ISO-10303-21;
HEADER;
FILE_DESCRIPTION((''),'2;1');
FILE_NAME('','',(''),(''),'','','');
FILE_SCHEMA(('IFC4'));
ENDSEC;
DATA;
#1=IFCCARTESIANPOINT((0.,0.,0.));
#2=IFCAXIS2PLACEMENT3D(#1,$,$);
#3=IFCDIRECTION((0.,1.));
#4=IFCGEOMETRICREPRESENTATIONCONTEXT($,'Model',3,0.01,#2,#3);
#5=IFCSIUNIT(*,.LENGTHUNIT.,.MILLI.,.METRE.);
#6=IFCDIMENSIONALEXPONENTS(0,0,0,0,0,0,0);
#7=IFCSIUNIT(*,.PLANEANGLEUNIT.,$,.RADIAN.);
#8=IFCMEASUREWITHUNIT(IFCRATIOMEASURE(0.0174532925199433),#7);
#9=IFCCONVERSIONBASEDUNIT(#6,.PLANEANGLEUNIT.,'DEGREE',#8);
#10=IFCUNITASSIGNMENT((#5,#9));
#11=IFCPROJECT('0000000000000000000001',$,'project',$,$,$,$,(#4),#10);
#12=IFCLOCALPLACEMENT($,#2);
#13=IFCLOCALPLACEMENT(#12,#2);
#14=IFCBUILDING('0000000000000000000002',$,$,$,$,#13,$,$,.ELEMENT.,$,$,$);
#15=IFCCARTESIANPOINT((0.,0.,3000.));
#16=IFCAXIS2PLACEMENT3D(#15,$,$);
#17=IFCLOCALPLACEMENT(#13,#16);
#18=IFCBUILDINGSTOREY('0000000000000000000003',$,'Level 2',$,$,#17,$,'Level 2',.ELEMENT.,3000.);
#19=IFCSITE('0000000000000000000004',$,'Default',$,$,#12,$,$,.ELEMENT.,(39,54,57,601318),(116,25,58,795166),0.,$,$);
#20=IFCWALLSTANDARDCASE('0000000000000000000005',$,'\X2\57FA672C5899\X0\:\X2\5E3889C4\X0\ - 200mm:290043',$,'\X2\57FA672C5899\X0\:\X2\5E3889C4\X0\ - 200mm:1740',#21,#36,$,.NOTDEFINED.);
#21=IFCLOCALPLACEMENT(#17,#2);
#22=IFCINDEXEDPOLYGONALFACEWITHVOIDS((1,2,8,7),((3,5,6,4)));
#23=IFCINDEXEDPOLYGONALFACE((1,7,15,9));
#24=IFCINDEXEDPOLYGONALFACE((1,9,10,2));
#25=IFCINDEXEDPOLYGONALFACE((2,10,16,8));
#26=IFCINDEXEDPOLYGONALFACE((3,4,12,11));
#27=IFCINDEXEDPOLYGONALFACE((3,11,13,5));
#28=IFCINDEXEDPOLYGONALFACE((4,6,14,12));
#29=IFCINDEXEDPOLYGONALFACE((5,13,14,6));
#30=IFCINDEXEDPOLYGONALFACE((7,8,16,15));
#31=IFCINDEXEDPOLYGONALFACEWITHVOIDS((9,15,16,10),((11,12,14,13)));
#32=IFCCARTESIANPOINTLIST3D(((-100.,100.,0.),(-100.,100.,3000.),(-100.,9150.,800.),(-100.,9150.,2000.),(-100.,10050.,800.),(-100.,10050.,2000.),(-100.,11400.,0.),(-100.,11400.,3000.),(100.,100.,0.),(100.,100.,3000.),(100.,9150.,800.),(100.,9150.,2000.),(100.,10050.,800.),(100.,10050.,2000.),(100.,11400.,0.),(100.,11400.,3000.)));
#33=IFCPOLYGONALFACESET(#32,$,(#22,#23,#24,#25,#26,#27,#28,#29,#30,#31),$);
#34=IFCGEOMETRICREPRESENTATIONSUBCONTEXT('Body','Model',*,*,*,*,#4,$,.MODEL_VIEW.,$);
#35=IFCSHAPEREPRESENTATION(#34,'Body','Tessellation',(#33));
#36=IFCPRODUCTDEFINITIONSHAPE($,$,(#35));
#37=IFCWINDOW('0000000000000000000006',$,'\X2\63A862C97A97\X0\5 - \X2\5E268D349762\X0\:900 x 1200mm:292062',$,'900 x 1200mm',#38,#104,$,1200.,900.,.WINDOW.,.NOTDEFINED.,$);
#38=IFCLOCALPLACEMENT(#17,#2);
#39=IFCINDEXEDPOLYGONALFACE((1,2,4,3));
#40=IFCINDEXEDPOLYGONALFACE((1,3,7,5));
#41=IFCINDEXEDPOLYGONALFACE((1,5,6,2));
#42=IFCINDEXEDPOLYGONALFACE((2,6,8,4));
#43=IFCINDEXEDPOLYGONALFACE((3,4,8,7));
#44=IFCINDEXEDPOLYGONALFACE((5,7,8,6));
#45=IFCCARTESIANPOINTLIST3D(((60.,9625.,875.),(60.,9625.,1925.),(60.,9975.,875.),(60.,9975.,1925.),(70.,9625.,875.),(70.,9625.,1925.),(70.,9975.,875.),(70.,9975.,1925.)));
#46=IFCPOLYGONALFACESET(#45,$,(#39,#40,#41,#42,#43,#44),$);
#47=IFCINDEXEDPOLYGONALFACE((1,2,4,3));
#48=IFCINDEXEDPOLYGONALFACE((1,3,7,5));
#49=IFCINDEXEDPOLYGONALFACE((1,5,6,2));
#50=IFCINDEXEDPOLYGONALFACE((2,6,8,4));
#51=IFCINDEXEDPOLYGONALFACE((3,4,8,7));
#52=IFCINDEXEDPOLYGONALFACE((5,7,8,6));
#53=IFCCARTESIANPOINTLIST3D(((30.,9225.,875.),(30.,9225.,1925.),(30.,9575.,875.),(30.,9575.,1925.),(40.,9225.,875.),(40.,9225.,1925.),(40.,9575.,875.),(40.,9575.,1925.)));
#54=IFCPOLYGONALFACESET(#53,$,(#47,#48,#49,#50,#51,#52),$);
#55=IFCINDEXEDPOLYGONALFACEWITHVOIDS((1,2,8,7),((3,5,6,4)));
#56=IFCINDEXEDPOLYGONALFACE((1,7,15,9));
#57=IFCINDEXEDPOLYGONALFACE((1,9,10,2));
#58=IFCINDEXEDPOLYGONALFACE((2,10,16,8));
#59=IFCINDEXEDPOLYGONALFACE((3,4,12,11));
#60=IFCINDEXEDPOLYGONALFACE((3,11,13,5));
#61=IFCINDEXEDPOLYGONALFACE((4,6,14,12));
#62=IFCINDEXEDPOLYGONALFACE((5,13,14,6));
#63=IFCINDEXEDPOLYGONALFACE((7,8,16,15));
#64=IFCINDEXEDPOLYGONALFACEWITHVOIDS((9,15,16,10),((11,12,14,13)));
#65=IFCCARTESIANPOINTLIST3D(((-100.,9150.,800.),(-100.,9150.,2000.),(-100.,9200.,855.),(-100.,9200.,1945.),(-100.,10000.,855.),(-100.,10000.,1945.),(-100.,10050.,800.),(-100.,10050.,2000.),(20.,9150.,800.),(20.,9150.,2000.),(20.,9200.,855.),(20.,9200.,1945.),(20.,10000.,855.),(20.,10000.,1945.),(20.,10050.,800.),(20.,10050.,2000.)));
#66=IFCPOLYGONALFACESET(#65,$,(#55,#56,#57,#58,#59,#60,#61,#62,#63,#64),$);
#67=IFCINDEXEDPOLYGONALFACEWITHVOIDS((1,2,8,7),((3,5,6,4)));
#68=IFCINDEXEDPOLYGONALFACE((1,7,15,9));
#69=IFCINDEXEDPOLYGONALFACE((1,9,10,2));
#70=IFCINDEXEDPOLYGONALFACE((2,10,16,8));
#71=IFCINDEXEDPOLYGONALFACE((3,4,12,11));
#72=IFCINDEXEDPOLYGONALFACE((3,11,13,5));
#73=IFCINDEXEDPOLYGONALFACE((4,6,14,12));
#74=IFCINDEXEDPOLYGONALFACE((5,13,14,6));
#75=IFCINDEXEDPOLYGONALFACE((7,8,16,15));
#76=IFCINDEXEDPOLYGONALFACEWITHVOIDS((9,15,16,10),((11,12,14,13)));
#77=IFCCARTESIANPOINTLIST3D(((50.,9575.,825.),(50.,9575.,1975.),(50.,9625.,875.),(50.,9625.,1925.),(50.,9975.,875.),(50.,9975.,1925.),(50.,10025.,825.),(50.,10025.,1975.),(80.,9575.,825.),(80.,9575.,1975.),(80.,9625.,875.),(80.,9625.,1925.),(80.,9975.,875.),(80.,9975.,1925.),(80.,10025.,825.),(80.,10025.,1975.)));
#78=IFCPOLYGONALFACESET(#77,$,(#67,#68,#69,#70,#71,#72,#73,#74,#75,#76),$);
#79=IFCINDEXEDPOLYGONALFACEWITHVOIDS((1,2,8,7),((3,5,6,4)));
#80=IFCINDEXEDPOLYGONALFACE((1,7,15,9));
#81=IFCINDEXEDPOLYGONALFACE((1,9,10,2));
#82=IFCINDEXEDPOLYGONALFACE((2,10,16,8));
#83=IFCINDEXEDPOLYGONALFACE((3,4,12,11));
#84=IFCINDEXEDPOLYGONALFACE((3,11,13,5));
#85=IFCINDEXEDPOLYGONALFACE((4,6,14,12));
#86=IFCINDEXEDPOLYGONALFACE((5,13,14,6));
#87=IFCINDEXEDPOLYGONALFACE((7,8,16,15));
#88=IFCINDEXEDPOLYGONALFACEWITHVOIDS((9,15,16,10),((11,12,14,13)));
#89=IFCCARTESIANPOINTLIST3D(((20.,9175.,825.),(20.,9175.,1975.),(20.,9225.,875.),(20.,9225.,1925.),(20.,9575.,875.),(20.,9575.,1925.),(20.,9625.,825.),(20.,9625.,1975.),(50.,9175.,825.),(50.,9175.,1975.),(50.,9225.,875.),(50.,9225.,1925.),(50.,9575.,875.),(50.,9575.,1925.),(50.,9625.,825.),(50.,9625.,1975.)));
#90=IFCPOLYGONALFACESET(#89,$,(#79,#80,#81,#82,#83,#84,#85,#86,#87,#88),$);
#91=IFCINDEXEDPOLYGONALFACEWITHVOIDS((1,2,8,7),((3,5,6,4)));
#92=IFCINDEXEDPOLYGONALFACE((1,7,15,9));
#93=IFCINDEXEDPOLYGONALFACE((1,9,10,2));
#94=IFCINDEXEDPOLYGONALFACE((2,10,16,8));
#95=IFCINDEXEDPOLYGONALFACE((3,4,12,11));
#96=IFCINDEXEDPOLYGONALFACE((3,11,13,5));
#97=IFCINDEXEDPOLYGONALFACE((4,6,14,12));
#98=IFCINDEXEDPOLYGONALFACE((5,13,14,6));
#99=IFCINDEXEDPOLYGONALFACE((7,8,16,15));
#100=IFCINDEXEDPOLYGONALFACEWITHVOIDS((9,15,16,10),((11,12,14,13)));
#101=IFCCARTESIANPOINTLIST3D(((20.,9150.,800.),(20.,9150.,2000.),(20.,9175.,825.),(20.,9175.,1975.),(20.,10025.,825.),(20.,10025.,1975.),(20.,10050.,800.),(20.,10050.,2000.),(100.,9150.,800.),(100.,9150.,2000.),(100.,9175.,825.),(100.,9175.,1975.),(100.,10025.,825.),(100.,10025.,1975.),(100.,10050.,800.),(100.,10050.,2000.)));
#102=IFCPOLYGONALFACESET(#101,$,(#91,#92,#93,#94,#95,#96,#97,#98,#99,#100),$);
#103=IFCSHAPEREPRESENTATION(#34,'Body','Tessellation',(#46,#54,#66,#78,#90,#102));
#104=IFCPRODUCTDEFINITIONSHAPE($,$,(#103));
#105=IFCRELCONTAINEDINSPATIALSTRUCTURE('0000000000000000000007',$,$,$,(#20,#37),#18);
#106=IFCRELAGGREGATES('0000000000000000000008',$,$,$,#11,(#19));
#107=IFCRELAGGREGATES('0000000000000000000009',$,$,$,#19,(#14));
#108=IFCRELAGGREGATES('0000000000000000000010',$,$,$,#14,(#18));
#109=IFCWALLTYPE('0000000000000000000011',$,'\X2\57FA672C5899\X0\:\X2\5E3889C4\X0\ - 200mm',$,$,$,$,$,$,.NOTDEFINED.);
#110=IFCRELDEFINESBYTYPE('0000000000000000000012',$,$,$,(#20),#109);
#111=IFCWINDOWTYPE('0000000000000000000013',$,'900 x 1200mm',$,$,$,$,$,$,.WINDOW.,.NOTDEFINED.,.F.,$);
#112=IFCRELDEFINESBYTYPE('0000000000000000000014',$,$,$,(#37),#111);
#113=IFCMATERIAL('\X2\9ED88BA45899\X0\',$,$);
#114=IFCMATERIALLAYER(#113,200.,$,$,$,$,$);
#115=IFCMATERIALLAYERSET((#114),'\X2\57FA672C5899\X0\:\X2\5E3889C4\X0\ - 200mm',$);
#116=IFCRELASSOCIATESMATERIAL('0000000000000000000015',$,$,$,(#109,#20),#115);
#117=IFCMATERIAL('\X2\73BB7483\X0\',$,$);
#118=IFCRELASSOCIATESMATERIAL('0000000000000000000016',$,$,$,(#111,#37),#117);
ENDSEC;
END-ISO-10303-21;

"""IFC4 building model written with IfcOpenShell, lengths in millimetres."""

from ifc_helpers import new_model, entity, si_unit, converted_unit, direction, frame, frame_2d, origin, origin_2d_with_axis, place, context, subcontext, project, spatial, polyline, rectangle, outline, extrude, source, transform, mapped, material, layer, layer_set, layer_usage, type_object, type_shapes, element, fill, save


model = new_model("IFC4")

# Units and contexts
model_context = context("Model", 3, precision=0.01, world=origin(), true_north=direction((0.0, 1.0)))
body_context = subcontext(model_context, "Body", "Model", "MODEL_VIEW")
ifc_project = project(units=[si_unit("LENGTHUNIT", "METRE", prefix="MILLI"), converted_unit("PLANEANGLEUNIT", "DEGREE", entity("IfcRatioMeasure", 0.0174532925199433), si_unit("PLANEANGLEUNIT", "RADIAN"), dimensions=[0, 0, 0, 0, 0, 0, 0])], contexts=[model_context])

# Site, building, storey
site_placement = place(None, origin())
site = spatial("IfcSite", under=ifc_project, at=site_placement, Name="Default", CompositionType="ELEMENT", RefLatitude=(39, 54, 57, 601318), RefLongitude=(116, 25, 58, 795166), RefElevation=0.0)
building_placement = place(site_placement, origin())
building = spatial("IfcBuilding", under=site, at=building_placement, CompositionType="ELEMENT")
storey_placement = place(building_placement, frame((0.0, 0.0, 3000.0)))
storey = spatial("IfcBuildingStorey", under=building, at=storey_placement, Name="Level 2", LongName="Level 2", CompositionType="ELEMENT", Elevation=3000.0)

# Shared definitions
ifc_material_1 = material(Name="默认墙")
ifc_layer_1 = layer(ifc_material_1, 200.0)
ifc_layer_set_1 = layer_set([ifc_layer_1], Name="基本墙:常规 - 200mm")
wall_type = type_object("IfcWallType", Name="基本墙:常规 - 200mm", PredefinedType="NOTDEFINED", material=ifc_layer_set_1)

# Wall, opening, window
ifc_material_2 = material(Name="玻璃")
window_type = type_object("IfcWindowType", Name="900 x 1200mm", ParameterTakesPrecedence=False, PartitioningType="NOTDEFINED", PredefinedType="WINDOW", material=ifc_material_2)
shared_shape_1 = source(origin(), body_context, "Body", "SweptSolid", [
    extrude(rectangle(XDim=10.0, YDim=350.0, at=origin_2d_with_axis()), frame((250.0, 165.0, 75.0), z_axis=(0.0, 0.0, 1.0), x_axis=(0.0, -1.0, 0.0)), (0.0, 0.0, 1.0), 1050.0),
    extrude(rectangle(XDim=10.0, YDim=350.0, at=origin_2d_with_axis()), frame((650.0, 135.0, 75.0), z_axis=(0.0, 0.0, 1.0), x_axis=(0.0, -1.0, 0.0)), (0.0, 0.0, 1.0), 1050.0),
    extrude(outline(polyline([(-450.0, -600.0), (450.0, -600.0), (450.0, 600.0), (-450.0, 600.0), (-450.0, -600.0)]), holes=[polyline([(400.0, -545.0), (-400.0, -545.0), (-400.0, 545.0), (400.0, 545.0), (400.0, -545.0)])]), frame((450.0, 0.0, 600.0), z_axis=(0.0, 1.0, 0.0), x_axis=(1.0, 0.0, 0.0)), (0.0, 0.0, 1.0), 120.0),
    extrude(outline(polyline([(-225.0, -575.0), (225.0, -575.0), (225.0, 575.0), (-225.0, 575.0), (-225.0, -575.0)]), holes=[polyline([(-175.0, -525.0), (-175.0, 525.0), (175.0, 525.0), (175.0, -525.0), (-175.0, -525.0)])]), frame((250.0, 150.0, 600.0), z_axis=(0.0, 1.0, 0.0), x_axis=(-1.0, 0.0, 0.0)), (0.0, 0.0, 1.0), 30.0),
    extrude(outline(polyline([(-225.0, -575.0), (225.0, -575.0), (225.0, 575.0), (-225.0, 575.0), (-225.0, -575.0)]), holes=[polyline([(-175.0, -525.0), (-175.0, 525.0), (175.0, 525.0), (175.0, -525.0), (-175.0, -525.0)])]), frame((650.0, 120.0, 600.0), z_axis=(0.0, 1.0, 0.0), x_axis=(1.0, 0.0, 0.0)), (0.0, 0.0, 1.0), 30.0),
    extrude(outline(polyline([(-450.0, -600.0), (450.0, -600.0), (450.0, 600.0), (-450.0, 600.0), (-450.0, -600.0)]), holes=[polyline([(-425.0, 575.0), (425.0, 575.0), (425.0, -575.0), (-425.0, -575.0), (-425.0, 575.0)])]), frame((450.0, 120.0, 600.0), z_axis=(0.0, 1.0, 0.0), x_axis=(1.0, 0.0, 0.0)), (0.0, 0.0, 1.0), 80.0),
])
type_shapes(window_type, [shared_shape_1])
ifc_layer_usage_1 = layer_usage(ifc_layer_set_1, "AXIS2", "NEGATIVE", 100.0)
wall_1_placement = place(storey_placement, frame((0.0, 100.0, 0.0), z_axis=(0.0, 0.0, 1.0), x_axis=(0.0, 1.0, 0.0)))
wall_1 = element("IfcWallStandardCase", 1, at=wall_1_placement, inside=storey, type_object=wall_type, material=ifc_layer_usage_1, Name="基本墙:常规 - 200mm:290043", ObjectType="基本墙:常规 - 200mm:1740", PredefinedType="NOTDEFINED", context=body_context, shape_type="SweptSolid", body=[
    extrude(rectangle(XDim=11300.0, YDim=200.0, at=frame_2d((5650.0, 0.0), x_axis=(-1.0, 0.0))), origin(), (0.0, 0.0, 1.0), 3000.0),
])
opening_1_placement = place(wall_1_placement, frame((9950.0, 100.0, 800.0)))
opening_1 = element("IfcOpeningElement", 2, at=opening_1_placement, cuts=wall_1, ObjectType="Opening", PredefinedType="OPENING", context=body_context, shape_type="SweptSolid", body=[
    extrude(rectangle(XDim=1200.0, YDim=900.0, at=frame_2d((600.0, 450.0), x_axis=(-1.0, 0.0))), frame((0.0, 0.0, 0.0), z_axis=(0.0, -1.0, 0.0), x_axis=(0.0, 0.0, 1.0)), (0.0, 0.0, 1.0), 200.0),
])
window_1_placement = place(opening_1_placement, frame((0.0, 0.0, 0.0), z_axis=(0.0, 0.0, 1.0), x_axis=(-1.0, 0.0, 0.0)))
window_1 = element("IfcWindow", 3, at=window_1_placement, inside=storey, type_object=window_type, material=ifc_material_2, Name="推拉窗5 - 带贴面:900 x 1200mm:292062", ObjectType="900 x 1200mm", OverallHeight=1200.0, OverallWidth=900.0, PartitioningType="NOTDEFINED", PredefinedType="WINDOW", context=body_context, shape_type="MappedRepresentation", body=[
    mapped(shared_shape_1, transform((0.0, 0.0, 0.0), scale=1.0)),
])
fill(opening_1, window_1)

save(model, "model.ifc")
